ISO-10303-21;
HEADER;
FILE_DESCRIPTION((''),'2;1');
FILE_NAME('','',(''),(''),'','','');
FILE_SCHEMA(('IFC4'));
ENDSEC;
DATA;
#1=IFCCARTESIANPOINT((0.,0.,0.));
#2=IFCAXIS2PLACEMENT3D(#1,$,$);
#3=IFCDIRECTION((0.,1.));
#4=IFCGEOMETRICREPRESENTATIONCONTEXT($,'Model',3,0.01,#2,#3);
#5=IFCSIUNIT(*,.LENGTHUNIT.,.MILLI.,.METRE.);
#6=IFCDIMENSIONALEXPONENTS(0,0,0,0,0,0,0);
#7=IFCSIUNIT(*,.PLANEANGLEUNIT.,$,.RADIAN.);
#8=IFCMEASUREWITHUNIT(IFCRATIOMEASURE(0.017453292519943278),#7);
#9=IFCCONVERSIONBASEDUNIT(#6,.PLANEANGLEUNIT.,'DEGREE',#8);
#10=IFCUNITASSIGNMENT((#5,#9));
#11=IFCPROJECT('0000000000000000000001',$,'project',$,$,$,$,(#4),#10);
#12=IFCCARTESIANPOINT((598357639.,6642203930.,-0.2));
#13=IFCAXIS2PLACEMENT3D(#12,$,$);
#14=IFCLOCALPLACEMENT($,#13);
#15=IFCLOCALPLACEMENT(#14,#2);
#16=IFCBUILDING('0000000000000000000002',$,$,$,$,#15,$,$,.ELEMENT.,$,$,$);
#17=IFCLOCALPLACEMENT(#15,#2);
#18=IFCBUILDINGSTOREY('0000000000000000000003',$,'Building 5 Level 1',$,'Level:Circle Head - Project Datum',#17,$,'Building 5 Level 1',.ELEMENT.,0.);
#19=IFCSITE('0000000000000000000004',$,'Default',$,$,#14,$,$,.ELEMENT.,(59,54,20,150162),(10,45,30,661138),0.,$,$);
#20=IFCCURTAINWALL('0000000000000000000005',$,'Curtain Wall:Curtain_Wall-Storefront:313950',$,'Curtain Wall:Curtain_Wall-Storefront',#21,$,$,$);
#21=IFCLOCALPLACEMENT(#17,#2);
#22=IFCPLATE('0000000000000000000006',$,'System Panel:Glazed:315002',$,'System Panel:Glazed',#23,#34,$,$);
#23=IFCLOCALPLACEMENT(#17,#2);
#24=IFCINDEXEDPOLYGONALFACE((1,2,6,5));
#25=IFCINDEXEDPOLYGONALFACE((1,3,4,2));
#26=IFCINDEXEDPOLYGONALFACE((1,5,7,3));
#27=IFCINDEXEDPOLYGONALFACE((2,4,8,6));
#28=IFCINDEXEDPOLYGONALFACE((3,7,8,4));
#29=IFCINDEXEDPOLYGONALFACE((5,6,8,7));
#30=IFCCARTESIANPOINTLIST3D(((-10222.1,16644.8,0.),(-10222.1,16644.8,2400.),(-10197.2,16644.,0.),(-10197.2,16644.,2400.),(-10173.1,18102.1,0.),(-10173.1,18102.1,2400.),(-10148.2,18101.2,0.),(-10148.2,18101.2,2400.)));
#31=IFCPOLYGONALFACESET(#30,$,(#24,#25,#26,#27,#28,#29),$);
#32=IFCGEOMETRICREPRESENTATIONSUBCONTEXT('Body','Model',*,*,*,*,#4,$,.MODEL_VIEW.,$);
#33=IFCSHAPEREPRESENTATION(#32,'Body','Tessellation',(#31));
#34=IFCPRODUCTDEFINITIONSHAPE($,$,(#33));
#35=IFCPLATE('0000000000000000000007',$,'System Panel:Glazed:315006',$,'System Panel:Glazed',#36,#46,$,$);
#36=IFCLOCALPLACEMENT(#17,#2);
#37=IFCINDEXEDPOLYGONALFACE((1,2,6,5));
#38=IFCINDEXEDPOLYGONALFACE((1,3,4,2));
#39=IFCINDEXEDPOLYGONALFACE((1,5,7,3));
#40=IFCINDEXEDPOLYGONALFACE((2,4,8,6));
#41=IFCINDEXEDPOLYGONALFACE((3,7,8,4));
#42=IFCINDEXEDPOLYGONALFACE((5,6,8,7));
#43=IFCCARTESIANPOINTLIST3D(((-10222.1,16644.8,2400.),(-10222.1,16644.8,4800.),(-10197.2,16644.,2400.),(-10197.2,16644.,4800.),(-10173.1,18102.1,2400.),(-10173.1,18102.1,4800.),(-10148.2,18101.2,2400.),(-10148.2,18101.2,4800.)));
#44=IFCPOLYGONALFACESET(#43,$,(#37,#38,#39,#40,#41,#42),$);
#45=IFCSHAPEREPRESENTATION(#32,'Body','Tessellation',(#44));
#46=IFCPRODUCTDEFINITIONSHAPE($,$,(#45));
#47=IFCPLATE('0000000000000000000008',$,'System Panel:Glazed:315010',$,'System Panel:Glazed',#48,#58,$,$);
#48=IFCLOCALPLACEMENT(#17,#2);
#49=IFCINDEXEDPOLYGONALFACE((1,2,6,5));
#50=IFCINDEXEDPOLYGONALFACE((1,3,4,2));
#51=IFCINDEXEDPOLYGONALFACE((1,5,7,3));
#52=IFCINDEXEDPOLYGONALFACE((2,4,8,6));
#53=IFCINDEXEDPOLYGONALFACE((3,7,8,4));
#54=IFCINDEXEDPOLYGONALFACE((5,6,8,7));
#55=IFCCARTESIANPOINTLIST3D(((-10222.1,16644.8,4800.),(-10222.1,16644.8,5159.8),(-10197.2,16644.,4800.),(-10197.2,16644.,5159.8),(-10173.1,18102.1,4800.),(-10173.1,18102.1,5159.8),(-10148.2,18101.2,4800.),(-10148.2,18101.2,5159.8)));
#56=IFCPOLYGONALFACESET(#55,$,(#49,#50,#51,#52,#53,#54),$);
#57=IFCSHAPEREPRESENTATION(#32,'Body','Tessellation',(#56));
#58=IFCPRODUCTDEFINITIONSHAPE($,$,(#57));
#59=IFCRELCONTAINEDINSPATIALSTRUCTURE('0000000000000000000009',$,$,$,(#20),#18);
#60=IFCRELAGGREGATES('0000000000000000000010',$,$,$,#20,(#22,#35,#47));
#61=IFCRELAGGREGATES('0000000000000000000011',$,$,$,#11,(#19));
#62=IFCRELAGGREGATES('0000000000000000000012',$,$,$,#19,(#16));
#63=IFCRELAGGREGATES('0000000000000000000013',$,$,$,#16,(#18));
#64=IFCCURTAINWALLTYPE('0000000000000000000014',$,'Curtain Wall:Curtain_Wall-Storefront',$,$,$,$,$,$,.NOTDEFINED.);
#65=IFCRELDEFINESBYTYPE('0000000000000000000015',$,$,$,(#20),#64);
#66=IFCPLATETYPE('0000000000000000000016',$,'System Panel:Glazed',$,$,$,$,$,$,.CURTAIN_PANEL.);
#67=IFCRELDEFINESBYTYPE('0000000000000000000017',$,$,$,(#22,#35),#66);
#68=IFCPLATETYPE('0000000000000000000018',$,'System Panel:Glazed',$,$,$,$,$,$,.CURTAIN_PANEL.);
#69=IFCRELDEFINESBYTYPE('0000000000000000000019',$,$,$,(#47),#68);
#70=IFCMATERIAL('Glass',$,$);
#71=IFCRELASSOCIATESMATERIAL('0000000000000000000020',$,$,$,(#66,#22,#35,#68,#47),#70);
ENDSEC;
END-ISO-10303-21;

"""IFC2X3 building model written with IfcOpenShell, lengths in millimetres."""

from ifc_helpers import new_model, entity, si_unit, converted_unit, direction, frame, frame_2d, origin, place, context, subcontext, project, spatial, rectangle, extrude, source, transform, mapped, material, type_object, type_shapes, element, aggregate, save


model = new_model("IFC2X3")

# Units and contexts
model_context = context("Model", 3, precision=0.01, world=origin(), true_north=direction((0.0, 1.0)))
body_context = subcontext(model_context, "Body", "Model", "MODEL_VIEW")
ifc_project = project(units=[si_unit("LENGTHUNIT", "METRE", prefix="MILLI"), converted_unit("PLANEANGLEUNIT", "DEGREE", entity("IfcRatioMeasure", 0.017453292519943278), si_unit("PLANEANGLEUNIT", "RADIAN"), dimensions=[0, 0, 0, 0, 0, 0, 0])], contexts=[model_context])

# Site, building, storey
site_placement = place(None, frame((598357639.0, 6642203930.0, -0.2)))
site = spatial("IfcSite", under=ifc_project, at=site_placement, Name="Default", CompositionType="ELEMENT", RefLatitude=(59, 54, 20, 150162), RefLongitude=(10, 45, 30, 661138), RefElevation=0.0)
building_placement = place(site_placement, origin())
building = spatial("IfcBuilding", under=site, at=building_placement, CompositionType="ELEMENT")
storey_placement = place(building_placement, origin())
storey = spatial("IfcBuildingStorey", under=building, at=storey_placement, Name="Building 5 Level 1", ObjectType="Level:Circle Head - Project Datum", LongName="Building 5 Level 1", CompositionType="ELEMENT", Elevation=0.0)

# Curtain wall, plates
curtain_wall_type = type_object("IfcCurtainWallType", Name="Curtain Wall:Curtain_Wall-Storefront", PredefinedType="NOTDEFINED")
curtain_wall_1_placement = place(storey_placement, origin())
curtain_wall_1 = element("IfcCurtainWall", 1, at=curtain_wall_1_placement, inside=storey, type_object=curtain_wall_type, Name="Curtain Wall:Curtain_Wall-Storefront:313950", ObjectType="Curtain Wall:Curtain_Wall-Storefront")
ifc_material_1 = material(Name="Glass")
plate_type_1 = type_object("IfcPlateType", Name="System Panel:Glazed", PredefinedType="CURTAIN_PANEL", material=ifc_material_1)
shared_shape_1 = source(origin(), body_context, "Body", "SweptSolid", [
    extrude(rectangle(XDim=25.0, YDim=1458.1, at=frame_2d((0.0, 0.0), x_axis=(1.0, 0.0))), frame((0.0, -37.0, 0.0), z_axis=(0.0, 0.0, 1.0), x_axis=(0.0, 1.0, 0.0)), (0.0, 0.0, 1.0), 2400.0),
])
type_shapes(plate_type_1, [shared_shape_1])
plate_1_placement = place(curtain_wall_1_placement, frame((-10148.2, 17371.8, 0.0), z_axis=(0.0, 0.0, 1.0), x_axis=(-0.033601, -0.999435, 0.0)))
plate_1 = element("IfcPlate", 2, at=plate_1_placement, type_object=plate_type_1, material=ifc_material_1, Name="System Panel:Glazed:315002", ObjectType="System Panel:Glazed", context=body_context, shape_type="MappedRepresentation", body=[
    mapped(shared_shape_1, transform((0.0, 0.0, 0.0), scale=1.0)),
])
plate_2_placement = place(curtain_wall_1_placement, frame((-10148.2, 17371.8, 2400.0), z_axis=(0.0, 0.0, 1.0), x_axis=(-0.033601, -0.999435, 0.0)))
plate_2 = element("IfcPlate", 3, at=plate_2_placement, type_object=plate_type_1, material=ifc_material_1, Name="System Panel:Glazed:315006", ObjectType="System Panel:Glazed", context=body_context, shape_type="MappedRepresentation", body=[
    mapped(shared_shape_1, transform((0.0, 0.0, 0.0), scale=1.0)),
])
plate_type_2 = type_object("IfcPlateType", Name="System Panel:Glazed", PredefinedType="CURTAIN_PANEL", material=ifc_material_1)
shared_shape_2 = source(origin(), body_context, "Body", "SweptSolid", [
    extrude(rectangle(XDim=25.0, YDim=1458.1, at=frame_2d((0.0, 0.0), x_axis=(1.0, 0.0))), frame((0.0, -37.0, 0.0), z_axis=(0.0, 0.0, 1.0), x_axis=(0.0, 1.0, 0.0)), (0.0, 0.0, 1.0), 359.8),
])
type_shapes(plate_type_2, [shared_shape_2])
plate_3_placement = place(curtain_wall_1_placement, frame((-10148.2, 17371.8, 4800.0), z_axis=(0.0, 0.0, 1.0), x_axis=(-0.033601, -0.999435, 0.0)))
plate_3 = element("IfcPlate", 4, at=plate_3_placement, type_object=plate_type_2, material=ifc_material_1, Name="System Panel:Glazed:315010", ObjectType="System Panel:Glazed", context=body_context, shape_type="MappedRepresentation", body=[
    mapped(shared_shape_2, transform((0.0, 0.0, 0.0), scale=1.0)),
])
aggregate(curtain_wall_1, [plate_1, plate_2, plate_3])

save(model, "model.ifc")
